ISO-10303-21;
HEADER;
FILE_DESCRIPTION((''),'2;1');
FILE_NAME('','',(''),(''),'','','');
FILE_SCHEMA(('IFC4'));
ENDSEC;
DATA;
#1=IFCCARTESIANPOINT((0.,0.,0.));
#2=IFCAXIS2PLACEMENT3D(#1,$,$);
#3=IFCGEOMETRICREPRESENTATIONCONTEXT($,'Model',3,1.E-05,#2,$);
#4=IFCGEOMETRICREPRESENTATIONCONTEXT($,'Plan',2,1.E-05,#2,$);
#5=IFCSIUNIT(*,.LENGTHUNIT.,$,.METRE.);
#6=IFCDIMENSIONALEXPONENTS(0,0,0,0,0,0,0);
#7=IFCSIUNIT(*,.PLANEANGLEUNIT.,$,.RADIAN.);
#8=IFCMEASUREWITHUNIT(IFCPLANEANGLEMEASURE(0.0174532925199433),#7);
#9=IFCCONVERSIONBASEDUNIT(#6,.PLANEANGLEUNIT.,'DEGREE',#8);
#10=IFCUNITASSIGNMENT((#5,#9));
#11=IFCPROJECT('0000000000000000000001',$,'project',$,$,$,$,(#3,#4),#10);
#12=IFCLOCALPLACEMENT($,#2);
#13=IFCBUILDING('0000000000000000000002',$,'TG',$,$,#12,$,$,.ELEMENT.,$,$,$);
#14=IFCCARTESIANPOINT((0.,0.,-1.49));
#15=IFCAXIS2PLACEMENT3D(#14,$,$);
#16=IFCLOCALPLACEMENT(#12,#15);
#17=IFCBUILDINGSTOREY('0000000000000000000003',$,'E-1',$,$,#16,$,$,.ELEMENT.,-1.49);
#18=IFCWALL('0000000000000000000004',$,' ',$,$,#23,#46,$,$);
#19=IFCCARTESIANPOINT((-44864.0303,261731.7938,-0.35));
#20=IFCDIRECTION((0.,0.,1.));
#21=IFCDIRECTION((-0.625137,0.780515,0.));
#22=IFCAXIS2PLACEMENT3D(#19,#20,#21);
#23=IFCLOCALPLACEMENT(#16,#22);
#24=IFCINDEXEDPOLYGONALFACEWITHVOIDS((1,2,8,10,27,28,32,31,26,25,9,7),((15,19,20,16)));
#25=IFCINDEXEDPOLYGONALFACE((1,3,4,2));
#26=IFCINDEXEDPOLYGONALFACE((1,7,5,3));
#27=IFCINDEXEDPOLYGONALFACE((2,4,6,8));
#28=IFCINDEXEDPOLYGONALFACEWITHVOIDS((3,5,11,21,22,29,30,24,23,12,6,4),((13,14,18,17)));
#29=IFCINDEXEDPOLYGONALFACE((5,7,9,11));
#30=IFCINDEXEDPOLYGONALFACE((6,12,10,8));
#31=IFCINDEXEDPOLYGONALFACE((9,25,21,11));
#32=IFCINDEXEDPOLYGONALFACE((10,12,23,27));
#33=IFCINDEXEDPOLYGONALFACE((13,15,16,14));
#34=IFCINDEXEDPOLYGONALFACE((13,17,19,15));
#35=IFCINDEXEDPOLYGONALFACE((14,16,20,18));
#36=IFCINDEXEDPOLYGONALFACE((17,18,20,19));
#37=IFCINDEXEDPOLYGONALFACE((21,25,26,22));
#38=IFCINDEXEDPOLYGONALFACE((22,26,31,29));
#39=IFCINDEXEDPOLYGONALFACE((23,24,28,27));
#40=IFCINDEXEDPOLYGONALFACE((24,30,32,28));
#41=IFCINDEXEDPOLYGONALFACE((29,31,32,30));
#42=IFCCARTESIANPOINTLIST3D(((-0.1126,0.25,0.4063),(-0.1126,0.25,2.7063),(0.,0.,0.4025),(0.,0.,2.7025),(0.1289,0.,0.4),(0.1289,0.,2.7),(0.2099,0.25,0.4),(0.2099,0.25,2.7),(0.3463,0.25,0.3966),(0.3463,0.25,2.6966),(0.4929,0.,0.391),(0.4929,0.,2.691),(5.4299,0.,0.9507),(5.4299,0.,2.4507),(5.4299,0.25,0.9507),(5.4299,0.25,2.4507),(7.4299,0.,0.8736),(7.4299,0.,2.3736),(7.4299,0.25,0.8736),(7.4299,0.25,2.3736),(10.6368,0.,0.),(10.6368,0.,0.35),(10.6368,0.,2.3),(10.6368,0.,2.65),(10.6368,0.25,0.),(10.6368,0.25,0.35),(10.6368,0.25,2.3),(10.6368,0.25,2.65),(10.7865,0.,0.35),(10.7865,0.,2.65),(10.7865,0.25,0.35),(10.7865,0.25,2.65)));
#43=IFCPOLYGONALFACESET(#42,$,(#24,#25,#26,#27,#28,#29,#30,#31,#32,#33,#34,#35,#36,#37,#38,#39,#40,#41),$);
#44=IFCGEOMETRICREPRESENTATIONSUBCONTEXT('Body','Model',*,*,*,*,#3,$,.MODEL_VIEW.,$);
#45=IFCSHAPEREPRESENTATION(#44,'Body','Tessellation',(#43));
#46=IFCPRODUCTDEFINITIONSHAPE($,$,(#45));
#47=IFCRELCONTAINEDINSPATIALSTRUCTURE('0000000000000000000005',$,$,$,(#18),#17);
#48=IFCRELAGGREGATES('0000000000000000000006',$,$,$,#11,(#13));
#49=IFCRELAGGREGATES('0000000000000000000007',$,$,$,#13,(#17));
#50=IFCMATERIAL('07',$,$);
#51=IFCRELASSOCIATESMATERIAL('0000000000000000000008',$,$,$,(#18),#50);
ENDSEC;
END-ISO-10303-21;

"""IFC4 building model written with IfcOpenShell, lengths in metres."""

from ifc_helpers import new_model, entity, si_unit, converted_unit, frame, origin, origin_with_axes, place, context, subcontext, project, spatial, polyline, outline, extrude, clip, bounded_halfspace, material, element, save


model = new_model("IFC4")

# Units and contexts
model_context = context("Model", 3, precision=1e-05, world=origin())
plan_context = context("Plan", 2, precision=1e-05, world=origin())
body_context = subcontext(model_context, "Body", "Model", "MODEL_VIEW")
ifc_project = project(units=[si_unit("LENGTHUNIT", "METRE"), converted_unit("PLANEANGLEUNIT", "DEGREE", entity("IfcPlaneAngleMeasure", 0.0174532925199433), si_unit("PLANEANGLEUNIT", "RADIAN"), dimensions=[0, 0, 0, 0, 0, 0, 0])], contexts=[model_context, plan_context])

# Building, storey
building_placement = place(None, origin())
building = spatial("IfcBuilding", under=ifc_project, at=building_placement, Name="TG", CompositionType="ELEMENT")
storey_placement = place(building_placement, frame((0.0, 0.0, -1.49)))
storey = spatial("IfcBuildingStorey", under=building, at=storey_placement, Name="E-1", CompositionType="ELEMENT", Elevation=-1.49)

# Wall, opening
ifc_material_1 = material(Name="07")
wall_1_placement = place(storey_placement, frame((-44864.0303, 261731.7938, -0.35), z_axis=(0.0, 0.0, 1.0), x_axis=(-0.625137, 0.780515, 0.0)))
wall_1 = element("IfcWall", 1, at=wall_1_placement, inside=storey, material=ifc_material_1, Name=" ", context=body_context, shape_type="Clipping", body=[
    clip(clip(clip(clip(clip(clip(clip(clip(extrude(outline(polyline([(-4.1468, -5.568), (6.6398, -5.568), (6.6398, -5.318), (-4.2593, -5.318), (-4.1468, -5.568)])), frame((4.1468, 5.568, 0.0), z_axis=(0.0, 0.0, 1.0), x_axis=(1.0, 0.0, 0.0)), (0.0, 0.0, 1.0), 2.7063), bounded_halfspace(frame((5.5282, 0.125, 0.1969), z_axis=(0.038513, 0.000001, 0.999258), x_axis=(0.505771, -0.862447, -0.019493)), True, origin_with_axes(), polyline([(0.3463, 0.25), (0.4929, 0.0), (10.6368, 0.0), (10.6368, 0.25), (0.3463, 0.25)]))), bounded_halfspace(frame((10.7116, 0.125, 0.35), z_axis=(0.0, 0.0, 1.0), x_axis=(-1.0, 0.0, 0.0)), True, origin_with_axes(), polyline([(10.7865, 0.25), (10.6368, 0.25), (10.6368, 0.0), (10.7865, 0.0), (10.7865, 0.25)]))), bounded_halfspace(frame((0.0566, 0.125, 0.4022), z_axis=(0.019459, -0.006309, 0.999791), x_axis=(0.410502, -0.911756, -0.013744)), True, origin_with_axes(), polyline([(-0.1126, 0.25), (0.0, 0.0), (0.1289, 0.0), (0.2099, 0.25), (-0.1126, 0.25)]))), bounded_halfspace(frame((0.2945, 0.125, 0.3969), z_axis=(0.02481, -0.008044, 0.99966), x_axis=(-0.308431, -0.951247, 0.0)), True, origin_with_axes(), polyline([(0.2099, 0.25), (0.1289, 0.0), (0.4929, 0.0), (0.3463, 0.25), (0.2099, 0.25)]))), bounded_halfspace(frame((5.5282, 0.125, 2.4969), z_axis=(-0.038513, -0.000001, -0.999258), x_axis=(0.999258, 0.0, -0.038513)), True, origin_with_axes(), polyline([(0.4929, 0.0), (10.6368, 0.0), (10.6368, 0.25), (0.3463, 0.25), (0.4929, 0.0)]))), bounded_halfspace(frame((10.7116, 0.125, 2.65), z_axis=(0.0, 0.0, -1.0), x_axis=(0.000029, -1.0, 0.0)), True, origin_with_axes(), polyline([(10.6368, 0.25), (10.6368, 0.0), (10.7865, 0.0), (10.7865, 0.25), (10.6368, 0.25)]))), bounded_halfspace(frame((0.0566, 0.125, 2.7022), z_axis=(-0.019459, 0.006309, -0.999791), x_axis=(0.999811, 0.0, -0.01946)), True, origin_with_axes(), polyline([(0.0, 0.0), (0.1289, 0.0), (0.2099, 0.25), (-0.1126, 0.25), (0.0, 0.0)]))), bounded_halfspace(frame((0.2945, 0.125, 2.6969), z_axis=(-0.02481, 0.008044, -0.99966), x_axis=(0.999692, 0.0, -0.024811)), True, origin_with_axes(), polyline([(0.1289, 0.0), (0.4929, 0.0), (0.3463, 0.25), (0.2099, 0.25), (0.1289, 0.0)]))),
])
opening_1_placement = place(wall_1_placement, frame((7.4299, 0.25, 0.8736), z_axis=(0.0, -1.0, 0.0), x_axis=(0.0, 0.0, 1.0)))
element("IfcOpeningElement", 2, at=opening_1_placement, cuts=wall_1, ObjectType="Opening", context=body_context, shape_type="SweptSolid", body=[
    extrude(outline(polyline([(0.0771, 2.0), (1.5771, 2.0), (1.5, 0.0), (0.0, 0.0), (0.0771, 2.0)])), origin_with_axes(), (0.0, 0.0, 1.0), 0.25),
])

save(model, "model.ifc")
